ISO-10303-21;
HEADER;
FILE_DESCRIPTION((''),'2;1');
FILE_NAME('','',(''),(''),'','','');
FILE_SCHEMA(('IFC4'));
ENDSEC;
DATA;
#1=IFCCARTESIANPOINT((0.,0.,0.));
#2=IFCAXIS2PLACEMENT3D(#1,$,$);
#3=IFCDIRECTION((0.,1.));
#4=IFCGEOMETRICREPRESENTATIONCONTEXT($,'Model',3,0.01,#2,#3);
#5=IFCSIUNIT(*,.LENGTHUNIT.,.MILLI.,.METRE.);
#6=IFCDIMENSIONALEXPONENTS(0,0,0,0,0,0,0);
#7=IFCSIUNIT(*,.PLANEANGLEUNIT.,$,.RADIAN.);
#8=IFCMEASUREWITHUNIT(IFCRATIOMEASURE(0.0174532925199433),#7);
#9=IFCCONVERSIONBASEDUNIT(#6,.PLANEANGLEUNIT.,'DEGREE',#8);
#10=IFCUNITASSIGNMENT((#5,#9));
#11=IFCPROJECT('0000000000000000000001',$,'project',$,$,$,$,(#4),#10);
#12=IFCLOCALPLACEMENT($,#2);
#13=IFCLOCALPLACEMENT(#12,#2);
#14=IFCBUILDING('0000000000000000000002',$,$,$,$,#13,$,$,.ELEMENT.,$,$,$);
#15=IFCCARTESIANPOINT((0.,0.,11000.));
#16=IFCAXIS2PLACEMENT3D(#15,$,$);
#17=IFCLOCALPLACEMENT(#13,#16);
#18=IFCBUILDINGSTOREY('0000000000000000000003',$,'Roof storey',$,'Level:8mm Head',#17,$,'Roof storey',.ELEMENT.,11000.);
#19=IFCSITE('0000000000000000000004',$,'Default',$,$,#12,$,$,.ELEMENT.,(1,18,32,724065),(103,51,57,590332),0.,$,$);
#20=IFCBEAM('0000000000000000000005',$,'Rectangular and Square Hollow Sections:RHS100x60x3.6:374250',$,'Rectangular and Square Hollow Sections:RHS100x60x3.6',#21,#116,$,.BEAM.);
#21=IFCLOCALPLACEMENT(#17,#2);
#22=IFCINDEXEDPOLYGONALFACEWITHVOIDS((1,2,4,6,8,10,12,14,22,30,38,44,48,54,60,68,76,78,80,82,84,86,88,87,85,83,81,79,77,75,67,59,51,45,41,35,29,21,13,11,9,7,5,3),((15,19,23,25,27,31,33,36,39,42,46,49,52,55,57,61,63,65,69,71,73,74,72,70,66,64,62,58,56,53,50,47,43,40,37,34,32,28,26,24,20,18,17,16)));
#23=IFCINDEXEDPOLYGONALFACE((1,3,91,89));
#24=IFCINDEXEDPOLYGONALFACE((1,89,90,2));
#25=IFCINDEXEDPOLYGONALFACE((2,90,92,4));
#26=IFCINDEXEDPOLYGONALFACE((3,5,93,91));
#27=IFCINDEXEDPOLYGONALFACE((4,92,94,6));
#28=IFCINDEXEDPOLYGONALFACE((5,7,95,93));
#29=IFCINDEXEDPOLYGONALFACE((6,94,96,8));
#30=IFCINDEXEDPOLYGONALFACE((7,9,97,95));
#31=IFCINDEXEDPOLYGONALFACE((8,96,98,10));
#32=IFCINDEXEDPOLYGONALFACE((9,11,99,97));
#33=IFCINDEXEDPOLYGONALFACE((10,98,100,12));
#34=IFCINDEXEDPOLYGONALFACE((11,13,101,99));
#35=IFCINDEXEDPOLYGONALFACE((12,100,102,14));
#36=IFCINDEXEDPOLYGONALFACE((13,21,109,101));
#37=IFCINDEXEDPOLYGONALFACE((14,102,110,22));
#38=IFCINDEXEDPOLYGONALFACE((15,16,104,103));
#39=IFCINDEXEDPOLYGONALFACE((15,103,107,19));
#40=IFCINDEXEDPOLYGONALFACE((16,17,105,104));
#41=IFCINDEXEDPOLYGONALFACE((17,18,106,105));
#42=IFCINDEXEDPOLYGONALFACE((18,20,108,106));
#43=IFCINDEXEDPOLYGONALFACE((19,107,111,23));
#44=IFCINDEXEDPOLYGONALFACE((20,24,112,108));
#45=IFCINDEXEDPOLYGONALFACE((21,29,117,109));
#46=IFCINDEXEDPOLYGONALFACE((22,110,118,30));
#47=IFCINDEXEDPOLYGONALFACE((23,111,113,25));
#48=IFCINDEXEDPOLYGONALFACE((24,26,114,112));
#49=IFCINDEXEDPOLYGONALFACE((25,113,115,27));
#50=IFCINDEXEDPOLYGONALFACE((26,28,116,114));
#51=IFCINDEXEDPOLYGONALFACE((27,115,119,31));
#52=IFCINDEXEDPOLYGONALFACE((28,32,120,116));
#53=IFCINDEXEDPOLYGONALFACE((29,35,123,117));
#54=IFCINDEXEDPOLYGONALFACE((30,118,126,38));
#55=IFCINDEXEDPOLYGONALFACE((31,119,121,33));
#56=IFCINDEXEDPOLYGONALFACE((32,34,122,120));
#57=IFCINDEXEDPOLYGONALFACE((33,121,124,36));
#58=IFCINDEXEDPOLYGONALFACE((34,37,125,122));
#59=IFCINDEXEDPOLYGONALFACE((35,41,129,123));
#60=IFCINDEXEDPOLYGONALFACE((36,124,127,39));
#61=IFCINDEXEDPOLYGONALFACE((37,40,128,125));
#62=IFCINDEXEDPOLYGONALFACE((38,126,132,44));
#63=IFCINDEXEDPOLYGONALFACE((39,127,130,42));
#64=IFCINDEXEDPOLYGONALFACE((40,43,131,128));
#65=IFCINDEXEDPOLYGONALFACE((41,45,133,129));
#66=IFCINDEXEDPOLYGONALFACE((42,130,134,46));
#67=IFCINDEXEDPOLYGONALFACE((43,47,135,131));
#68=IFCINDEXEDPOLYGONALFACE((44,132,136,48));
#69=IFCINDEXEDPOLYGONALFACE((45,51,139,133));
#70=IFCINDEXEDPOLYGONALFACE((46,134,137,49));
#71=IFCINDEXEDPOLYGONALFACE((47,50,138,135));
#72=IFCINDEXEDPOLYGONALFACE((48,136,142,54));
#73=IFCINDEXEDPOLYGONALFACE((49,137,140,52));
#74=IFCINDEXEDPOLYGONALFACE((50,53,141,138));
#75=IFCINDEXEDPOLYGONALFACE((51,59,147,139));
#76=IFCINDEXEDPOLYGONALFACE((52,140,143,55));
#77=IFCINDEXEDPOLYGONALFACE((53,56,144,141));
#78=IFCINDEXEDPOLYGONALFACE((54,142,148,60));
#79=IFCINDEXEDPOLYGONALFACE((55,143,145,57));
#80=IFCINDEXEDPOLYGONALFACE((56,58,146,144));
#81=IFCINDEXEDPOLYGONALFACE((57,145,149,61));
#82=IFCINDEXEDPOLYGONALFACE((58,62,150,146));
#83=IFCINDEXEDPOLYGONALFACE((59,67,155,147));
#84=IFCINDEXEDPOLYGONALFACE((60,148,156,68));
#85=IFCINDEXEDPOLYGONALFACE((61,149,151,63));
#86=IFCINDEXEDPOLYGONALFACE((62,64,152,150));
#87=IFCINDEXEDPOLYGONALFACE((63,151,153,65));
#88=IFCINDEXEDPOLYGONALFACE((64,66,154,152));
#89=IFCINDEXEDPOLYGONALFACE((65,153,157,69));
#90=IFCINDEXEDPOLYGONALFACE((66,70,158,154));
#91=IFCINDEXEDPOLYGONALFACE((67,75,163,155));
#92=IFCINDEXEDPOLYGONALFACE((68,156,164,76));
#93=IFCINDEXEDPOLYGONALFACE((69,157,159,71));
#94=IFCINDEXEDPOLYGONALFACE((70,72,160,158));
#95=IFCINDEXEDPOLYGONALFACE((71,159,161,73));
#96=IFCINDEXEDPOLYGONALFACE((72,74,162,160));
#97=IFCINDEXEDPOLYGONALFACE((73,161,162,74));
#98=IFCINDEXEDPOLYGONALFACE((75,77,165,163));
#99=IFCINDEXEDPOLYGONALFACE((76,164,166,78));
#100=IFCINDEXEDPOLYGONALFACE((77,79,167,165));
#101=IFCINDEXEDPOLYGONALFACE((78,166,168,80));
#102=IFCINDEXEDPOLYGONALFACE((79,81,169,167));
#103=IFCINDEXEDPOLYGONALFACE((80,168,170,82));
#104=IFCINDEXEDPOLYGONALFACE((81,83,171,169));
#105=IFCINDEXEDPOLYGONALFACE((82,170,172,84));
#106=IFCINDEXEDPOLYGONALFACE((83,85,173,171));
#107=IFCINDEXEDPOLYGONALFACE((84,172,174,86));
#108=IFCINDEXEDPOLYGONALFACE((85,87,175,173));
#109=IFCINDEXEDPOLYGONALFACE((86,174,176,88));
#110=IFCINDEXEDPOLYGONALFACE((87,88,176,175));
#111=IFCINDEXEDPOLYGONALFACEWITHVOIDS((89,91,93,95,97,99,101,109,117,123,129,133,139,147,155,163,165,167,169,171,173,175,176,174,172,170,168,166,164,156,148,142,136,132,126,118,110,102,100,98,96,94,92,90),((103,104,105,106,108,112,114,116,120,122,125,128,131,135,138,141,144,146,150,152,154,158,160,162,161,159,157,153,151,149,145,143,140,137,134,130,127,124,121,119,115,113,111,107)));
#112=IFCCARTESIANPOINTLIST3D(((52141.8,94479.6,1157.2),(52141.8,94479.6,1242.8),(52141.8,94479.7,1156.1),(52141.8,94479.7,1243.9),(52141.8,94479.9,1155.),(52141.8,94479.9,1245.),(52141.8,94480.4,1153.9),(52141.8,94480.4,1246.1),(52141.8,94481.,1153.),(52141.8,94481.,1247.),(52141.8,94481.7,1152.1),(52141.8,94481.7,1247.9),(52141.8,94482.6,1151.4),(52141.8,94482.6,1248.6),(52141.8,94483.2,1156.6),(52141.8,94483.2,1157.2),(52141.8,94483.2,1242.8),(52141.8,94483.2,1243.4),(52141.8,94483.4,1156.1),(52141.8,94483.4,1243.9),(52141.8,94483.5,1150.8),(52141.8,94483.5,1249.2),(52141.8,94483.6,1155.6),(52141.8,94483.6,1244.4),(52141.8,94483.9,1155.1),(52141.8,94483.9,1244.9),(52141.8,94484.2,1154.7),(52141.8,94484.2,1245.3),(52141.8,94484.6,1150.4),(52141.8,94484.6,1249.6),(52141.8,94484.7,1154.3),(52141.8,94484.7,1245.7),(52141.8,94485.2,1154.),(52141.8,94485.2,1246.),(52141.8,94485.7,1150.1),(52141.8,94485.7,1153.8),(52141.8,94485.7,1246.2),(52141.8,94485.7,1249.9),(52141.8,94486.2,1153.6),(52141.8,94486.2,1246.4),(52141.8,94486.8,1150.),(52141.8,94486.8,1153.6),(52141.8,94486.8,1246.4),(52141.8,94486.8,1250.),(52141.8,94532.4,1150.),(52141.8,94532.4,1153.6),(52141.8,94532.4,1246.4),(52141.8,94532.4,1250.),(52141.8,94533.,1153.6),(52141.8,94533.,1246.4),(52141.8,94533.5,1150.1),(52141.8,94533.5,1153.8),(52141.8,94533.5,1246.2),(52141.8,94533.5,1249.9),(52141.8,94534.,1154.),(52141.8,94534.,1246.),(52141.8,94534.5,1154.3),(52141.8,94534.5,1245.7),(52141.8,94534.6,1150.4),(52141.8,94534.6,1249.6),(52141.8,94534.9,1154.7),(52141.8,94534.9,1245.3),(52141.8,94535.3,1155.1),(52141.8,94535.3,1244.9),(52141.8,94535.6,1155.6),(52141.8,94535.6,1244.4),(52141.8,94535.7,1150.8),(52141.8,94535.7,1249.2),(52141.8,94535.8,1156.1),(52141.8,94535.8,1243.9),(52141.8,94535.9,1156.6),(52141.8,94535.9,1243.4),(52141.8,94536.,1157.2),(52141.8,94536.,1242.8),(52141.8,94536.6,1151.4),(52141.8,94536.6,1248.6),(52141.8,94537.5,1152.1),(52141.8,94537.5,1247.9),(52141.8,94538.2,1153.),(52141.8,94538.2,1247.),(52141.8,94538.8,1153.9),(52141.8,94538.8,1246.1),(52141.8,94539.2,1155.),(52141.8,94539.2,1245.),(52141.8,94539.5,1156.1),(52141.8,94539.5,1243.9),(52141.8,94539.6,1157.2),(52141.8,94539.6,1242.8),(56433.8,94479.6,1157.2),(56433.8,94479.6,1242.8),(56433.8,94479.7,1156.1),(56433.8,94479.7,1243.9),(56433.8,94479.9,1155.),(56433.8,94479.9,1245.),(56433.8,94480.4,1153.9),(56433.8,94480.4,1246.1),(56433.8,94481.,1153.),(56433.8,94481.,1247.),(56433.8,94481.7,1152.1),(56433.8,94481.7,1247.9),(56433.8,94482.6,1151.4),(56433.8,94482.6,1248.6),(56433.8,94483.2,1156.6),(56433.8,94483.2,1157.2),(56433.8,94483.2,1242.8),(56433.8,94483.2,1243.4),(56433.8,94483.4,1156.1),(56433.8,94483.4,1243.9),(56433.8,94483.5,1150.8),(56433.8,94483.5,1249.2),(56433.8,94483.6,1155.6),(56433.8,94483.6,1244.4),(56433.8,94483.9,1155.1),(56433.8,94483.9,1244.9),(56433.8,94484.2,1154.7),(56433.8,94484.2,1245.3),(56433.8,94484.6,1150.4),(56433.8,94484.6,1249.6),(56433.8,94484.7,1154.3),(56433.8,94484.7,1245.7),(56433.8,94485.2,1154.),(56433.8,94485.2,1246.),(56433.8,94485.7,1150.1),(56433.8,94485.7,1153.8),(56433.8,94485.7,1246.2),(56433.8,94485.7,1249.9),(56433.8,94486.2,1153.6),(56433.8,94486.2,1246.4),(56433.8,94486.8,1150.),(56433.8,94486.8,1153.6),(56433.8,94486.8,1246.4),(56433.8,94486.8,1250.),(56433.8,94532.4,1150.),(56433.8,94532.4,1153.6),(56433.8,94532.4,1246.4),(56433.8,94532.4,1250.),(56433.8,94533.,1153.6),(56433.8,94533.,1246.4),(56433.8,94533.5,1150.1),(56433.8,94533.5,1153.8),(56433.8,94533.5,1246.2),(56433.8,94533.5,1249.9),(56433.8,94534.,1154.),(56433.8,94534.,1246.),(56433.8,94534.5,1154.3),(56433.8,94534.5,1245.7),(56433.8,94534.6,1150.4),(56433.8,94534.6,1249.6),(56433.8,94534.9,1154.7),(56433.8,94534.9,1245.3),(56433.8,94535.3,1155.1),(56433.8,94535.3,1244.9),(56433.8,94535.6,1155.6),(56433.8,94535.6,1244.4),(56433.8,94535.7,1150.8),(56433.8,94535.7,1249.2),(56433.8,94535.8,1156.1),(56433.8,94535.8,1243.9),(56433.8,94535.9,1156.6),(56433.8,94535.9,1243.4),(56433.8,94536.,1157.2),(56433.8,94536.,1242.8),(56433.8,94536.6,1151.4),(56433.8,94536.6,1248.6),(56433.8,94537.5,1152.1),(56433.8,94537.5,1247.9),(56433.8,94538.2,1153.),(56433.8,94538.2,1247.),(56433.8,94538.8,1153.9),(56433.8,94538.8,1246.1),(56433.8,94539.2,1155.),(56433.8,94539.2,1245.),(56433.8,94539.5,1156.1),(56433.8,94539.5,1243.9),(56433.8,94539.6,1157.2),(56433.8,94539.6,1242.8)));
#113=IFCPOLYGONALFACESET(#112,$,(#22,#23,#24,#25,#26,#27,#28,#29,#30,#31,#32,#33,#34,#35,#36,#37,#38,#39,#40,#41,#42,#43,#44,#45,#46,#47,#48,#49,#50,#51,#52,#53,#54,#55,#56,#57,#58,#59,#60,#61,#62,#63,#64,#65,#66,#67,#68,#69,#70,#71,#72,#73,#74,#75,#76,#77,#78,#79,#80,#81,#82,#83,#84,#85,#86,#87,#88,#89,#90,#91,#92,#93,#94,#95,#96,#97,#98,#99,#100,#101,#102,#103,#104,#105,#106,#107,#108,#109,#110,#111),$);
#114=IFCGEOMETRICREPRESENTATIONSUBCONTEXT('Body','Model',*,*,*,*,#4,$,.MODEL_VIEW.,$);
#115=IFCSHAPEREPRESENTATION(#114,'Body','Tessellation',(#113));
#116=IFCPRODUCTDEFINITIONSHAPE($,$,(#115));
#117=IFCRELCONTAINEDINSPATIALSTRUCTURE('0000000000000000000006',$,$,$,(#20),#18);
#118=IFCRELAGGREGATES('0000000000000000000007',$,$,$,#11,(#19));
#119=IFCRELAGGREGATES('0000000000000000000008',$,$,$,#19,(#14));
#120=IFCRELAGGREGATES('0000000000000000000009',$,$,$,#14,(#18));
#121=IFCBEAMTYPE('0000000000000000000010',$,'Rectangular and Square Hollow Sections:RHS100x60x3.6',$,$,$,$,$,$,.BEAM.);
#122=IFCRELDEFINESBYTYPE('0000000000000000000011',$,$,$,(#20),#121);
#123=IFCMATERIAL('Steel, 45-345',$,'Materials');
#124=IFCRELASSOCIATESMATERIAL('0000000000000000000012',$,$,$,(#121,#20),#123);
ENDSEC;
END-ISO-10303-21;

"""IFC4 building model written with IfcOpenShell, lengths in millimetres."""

from ifc_helpers import new_model, entity, si_unit, converted_unit, direction, frame, origin, place, context, subcontext, project, spatial, indexed_curve, outline, extrude, source, transform, mapped, material, type_object, type_shapes, element, save


model = new_model("IFC4")

# Units and contexts
model_context = context("Model", 3, precision=0.01, world=origin(), true_north=direction((0.0, 1.0)))
body_context = subcontext(model_context, "Body", "Model", "MODEL_VIEW")
ifc_project = project(units=[si_unit("LENGTHUNIT", "METRE", prefix="MILLI"), converted_unit("PLANEANGLEUNIT", "DEGREE", entity("IfcRatioMeasure", 0.0174532925199433), si_unit("PLANEANGLEUNIT", "RADIAN"), dimensions=[0, 0, 0, 0, 0, 0, 0])], contexts=[model_context])

# Site, building, storey
site_placement = place(None, origin())
site = spatial("IfcSite", under=ifc_project, at=site_placement, Name="Default", CompositionType="ELEMENT", RefLatitude=(1, 18, 32, 724065), RefLongitude=(103, 51, 57, 590332), RefElevation=0.0)
building_placement = place(site_placement, origin())
building = spatial("IfcBuilding", under=site, at=building_placement, CompositionType="ELEMENT")
storey_placement = place(building_placement, frame((0.0, 0.0, 11000.0)))
storey = spatial("IfcBuildingStorey", under=building, at=storey_placement, Name="Roof storey", ObjectType="Level:8mm Head", LongName="Roof storey", CompositionType="ELEMENT", Elevation=11000.0)

# Shared definitions
ifc_material = material(Name="Steel, 45-345", Category="Materials")

# Beam
beam_type_1 = type_object("IfcBeamType", Name="Rectangular and Square Hollow Sections:RHS100x60x3.6", PredefinedType="BEAM", material=ifc_material)
shared_shape_1 = source(origin(), body_context, "Body", "SweptSolid", [
    extrude(outline(indexed_curve([(-30.0, -42.8), (-29.9, -43.9), (-29.6, -45.0), (-29.2, -46.1), (-28.6, -47.0), (-27.9, -47.9), (-27.0, -48.6), (-26.1, -49.2), (-25.0, -49.6), (-23.9, -49.9), (-22.8, -50.0), (22.8, -50.0), (23.9, -49.9), (25.0, -49.6), (26.1, -49.2), (27.0, -48.6), (27.9, -47.9), (28.6, -47.0), (29.2, -46.1), (29.6, -45.0), (29.9, -43.9), (30.0, -42.8), (30.0, 42.8), (29.9, 43.9), (29.6, 45.0), (29.2, 46.1), (28.6, 47.0), (27.9, 47.9), (27.0, 48.6), (26.1, 49.2), (25.0, 49.6), (23.9, 49.9), (22.8, 50.0), (-22.8, 50.0), (-23.9, 49.9), (-25.0, 49.6), (-26.1, 49.2), (-27.0, 48.6), (-27.9, 47.9), (-28.6, 47.0), (-29.2, 46.1), (-29.6, 45.0), (-29.9, 43.9), (-30.0, 42.8), (-30.0, -42.8)], self_intersect=False), holes=[indexed_curve([(22.8, -46.4), (-22.8, -46.4), (-23.4, -46.4), (-23.9, -46.2), (-24.4, -46.0), (-24.9, -45.7), (-25.3, -45.3), (-25.7, -44.9), (-26.0, -44.4), (-26.2, -43.9), (-26.4, -43.4), (-26.4, -42.8), (-26.4, 42.8), (-26.4, 43.4), (-26.2, 43.9), (-26.0, 44.4), (-25.7, 44.9), (-25.3, 45.3), (-24.9, 45.7), (-24.4, 46.0), (-23.9, 46.2), (-23.4, 46.4), (-22.8, 46.4), (22.8, 46.4), (23.4, 46.4), (23.9, 46.2), (24.4, 46.0), (24.9, 45.7), (25.3, 45.3), (25.7, 44.9), (26.0, 44.4), (26.2, 43.9), (26.4, 43.4), (26.4, 42.8), (26.4, -42.8), (26.4, -43.4), (26.2, -43.9), (26.0, -44.4), (25.7, -44.9), (25.3, -45.3), (24.9, -45.7), (24.4, -46.0), (23.9, -46.2), (23.4, -46.4), (22.8, -46.4)], self_intersect=False)]), frame((-2152.5, 0.0, 0.0), z_axis=(1.0, 0.0, 0.0), x_axis=(0.0, -1.0, 0.0)), (0.0, 0.0, 1.0), 4292.0),
])
type_shapes(beam_type_1, [shared_shape_1])
for number, where, name in (
    (1, (54294.3, 94509.6, 1200.0), "Rectangular and Square Hollow Sections:RHS100x60x3.6:374250"),
):
    element("IfcBeam", number, at=place(storey_placement, frame(where)), inside=storey, type_object=beam_type_1, material=ifc_material, Name=name, ObjectType="Rectangular and Square Hollow Sections:RHS100x60x3.6", PredefinedType="BEAM", context=body_context, shape_type="MappedRepresentation", body=[
        mapped(shared_shape_1, transform((0.0, 0.0, 0.0), scale=1.0)),
    ])

save(model, "model.ifc")
